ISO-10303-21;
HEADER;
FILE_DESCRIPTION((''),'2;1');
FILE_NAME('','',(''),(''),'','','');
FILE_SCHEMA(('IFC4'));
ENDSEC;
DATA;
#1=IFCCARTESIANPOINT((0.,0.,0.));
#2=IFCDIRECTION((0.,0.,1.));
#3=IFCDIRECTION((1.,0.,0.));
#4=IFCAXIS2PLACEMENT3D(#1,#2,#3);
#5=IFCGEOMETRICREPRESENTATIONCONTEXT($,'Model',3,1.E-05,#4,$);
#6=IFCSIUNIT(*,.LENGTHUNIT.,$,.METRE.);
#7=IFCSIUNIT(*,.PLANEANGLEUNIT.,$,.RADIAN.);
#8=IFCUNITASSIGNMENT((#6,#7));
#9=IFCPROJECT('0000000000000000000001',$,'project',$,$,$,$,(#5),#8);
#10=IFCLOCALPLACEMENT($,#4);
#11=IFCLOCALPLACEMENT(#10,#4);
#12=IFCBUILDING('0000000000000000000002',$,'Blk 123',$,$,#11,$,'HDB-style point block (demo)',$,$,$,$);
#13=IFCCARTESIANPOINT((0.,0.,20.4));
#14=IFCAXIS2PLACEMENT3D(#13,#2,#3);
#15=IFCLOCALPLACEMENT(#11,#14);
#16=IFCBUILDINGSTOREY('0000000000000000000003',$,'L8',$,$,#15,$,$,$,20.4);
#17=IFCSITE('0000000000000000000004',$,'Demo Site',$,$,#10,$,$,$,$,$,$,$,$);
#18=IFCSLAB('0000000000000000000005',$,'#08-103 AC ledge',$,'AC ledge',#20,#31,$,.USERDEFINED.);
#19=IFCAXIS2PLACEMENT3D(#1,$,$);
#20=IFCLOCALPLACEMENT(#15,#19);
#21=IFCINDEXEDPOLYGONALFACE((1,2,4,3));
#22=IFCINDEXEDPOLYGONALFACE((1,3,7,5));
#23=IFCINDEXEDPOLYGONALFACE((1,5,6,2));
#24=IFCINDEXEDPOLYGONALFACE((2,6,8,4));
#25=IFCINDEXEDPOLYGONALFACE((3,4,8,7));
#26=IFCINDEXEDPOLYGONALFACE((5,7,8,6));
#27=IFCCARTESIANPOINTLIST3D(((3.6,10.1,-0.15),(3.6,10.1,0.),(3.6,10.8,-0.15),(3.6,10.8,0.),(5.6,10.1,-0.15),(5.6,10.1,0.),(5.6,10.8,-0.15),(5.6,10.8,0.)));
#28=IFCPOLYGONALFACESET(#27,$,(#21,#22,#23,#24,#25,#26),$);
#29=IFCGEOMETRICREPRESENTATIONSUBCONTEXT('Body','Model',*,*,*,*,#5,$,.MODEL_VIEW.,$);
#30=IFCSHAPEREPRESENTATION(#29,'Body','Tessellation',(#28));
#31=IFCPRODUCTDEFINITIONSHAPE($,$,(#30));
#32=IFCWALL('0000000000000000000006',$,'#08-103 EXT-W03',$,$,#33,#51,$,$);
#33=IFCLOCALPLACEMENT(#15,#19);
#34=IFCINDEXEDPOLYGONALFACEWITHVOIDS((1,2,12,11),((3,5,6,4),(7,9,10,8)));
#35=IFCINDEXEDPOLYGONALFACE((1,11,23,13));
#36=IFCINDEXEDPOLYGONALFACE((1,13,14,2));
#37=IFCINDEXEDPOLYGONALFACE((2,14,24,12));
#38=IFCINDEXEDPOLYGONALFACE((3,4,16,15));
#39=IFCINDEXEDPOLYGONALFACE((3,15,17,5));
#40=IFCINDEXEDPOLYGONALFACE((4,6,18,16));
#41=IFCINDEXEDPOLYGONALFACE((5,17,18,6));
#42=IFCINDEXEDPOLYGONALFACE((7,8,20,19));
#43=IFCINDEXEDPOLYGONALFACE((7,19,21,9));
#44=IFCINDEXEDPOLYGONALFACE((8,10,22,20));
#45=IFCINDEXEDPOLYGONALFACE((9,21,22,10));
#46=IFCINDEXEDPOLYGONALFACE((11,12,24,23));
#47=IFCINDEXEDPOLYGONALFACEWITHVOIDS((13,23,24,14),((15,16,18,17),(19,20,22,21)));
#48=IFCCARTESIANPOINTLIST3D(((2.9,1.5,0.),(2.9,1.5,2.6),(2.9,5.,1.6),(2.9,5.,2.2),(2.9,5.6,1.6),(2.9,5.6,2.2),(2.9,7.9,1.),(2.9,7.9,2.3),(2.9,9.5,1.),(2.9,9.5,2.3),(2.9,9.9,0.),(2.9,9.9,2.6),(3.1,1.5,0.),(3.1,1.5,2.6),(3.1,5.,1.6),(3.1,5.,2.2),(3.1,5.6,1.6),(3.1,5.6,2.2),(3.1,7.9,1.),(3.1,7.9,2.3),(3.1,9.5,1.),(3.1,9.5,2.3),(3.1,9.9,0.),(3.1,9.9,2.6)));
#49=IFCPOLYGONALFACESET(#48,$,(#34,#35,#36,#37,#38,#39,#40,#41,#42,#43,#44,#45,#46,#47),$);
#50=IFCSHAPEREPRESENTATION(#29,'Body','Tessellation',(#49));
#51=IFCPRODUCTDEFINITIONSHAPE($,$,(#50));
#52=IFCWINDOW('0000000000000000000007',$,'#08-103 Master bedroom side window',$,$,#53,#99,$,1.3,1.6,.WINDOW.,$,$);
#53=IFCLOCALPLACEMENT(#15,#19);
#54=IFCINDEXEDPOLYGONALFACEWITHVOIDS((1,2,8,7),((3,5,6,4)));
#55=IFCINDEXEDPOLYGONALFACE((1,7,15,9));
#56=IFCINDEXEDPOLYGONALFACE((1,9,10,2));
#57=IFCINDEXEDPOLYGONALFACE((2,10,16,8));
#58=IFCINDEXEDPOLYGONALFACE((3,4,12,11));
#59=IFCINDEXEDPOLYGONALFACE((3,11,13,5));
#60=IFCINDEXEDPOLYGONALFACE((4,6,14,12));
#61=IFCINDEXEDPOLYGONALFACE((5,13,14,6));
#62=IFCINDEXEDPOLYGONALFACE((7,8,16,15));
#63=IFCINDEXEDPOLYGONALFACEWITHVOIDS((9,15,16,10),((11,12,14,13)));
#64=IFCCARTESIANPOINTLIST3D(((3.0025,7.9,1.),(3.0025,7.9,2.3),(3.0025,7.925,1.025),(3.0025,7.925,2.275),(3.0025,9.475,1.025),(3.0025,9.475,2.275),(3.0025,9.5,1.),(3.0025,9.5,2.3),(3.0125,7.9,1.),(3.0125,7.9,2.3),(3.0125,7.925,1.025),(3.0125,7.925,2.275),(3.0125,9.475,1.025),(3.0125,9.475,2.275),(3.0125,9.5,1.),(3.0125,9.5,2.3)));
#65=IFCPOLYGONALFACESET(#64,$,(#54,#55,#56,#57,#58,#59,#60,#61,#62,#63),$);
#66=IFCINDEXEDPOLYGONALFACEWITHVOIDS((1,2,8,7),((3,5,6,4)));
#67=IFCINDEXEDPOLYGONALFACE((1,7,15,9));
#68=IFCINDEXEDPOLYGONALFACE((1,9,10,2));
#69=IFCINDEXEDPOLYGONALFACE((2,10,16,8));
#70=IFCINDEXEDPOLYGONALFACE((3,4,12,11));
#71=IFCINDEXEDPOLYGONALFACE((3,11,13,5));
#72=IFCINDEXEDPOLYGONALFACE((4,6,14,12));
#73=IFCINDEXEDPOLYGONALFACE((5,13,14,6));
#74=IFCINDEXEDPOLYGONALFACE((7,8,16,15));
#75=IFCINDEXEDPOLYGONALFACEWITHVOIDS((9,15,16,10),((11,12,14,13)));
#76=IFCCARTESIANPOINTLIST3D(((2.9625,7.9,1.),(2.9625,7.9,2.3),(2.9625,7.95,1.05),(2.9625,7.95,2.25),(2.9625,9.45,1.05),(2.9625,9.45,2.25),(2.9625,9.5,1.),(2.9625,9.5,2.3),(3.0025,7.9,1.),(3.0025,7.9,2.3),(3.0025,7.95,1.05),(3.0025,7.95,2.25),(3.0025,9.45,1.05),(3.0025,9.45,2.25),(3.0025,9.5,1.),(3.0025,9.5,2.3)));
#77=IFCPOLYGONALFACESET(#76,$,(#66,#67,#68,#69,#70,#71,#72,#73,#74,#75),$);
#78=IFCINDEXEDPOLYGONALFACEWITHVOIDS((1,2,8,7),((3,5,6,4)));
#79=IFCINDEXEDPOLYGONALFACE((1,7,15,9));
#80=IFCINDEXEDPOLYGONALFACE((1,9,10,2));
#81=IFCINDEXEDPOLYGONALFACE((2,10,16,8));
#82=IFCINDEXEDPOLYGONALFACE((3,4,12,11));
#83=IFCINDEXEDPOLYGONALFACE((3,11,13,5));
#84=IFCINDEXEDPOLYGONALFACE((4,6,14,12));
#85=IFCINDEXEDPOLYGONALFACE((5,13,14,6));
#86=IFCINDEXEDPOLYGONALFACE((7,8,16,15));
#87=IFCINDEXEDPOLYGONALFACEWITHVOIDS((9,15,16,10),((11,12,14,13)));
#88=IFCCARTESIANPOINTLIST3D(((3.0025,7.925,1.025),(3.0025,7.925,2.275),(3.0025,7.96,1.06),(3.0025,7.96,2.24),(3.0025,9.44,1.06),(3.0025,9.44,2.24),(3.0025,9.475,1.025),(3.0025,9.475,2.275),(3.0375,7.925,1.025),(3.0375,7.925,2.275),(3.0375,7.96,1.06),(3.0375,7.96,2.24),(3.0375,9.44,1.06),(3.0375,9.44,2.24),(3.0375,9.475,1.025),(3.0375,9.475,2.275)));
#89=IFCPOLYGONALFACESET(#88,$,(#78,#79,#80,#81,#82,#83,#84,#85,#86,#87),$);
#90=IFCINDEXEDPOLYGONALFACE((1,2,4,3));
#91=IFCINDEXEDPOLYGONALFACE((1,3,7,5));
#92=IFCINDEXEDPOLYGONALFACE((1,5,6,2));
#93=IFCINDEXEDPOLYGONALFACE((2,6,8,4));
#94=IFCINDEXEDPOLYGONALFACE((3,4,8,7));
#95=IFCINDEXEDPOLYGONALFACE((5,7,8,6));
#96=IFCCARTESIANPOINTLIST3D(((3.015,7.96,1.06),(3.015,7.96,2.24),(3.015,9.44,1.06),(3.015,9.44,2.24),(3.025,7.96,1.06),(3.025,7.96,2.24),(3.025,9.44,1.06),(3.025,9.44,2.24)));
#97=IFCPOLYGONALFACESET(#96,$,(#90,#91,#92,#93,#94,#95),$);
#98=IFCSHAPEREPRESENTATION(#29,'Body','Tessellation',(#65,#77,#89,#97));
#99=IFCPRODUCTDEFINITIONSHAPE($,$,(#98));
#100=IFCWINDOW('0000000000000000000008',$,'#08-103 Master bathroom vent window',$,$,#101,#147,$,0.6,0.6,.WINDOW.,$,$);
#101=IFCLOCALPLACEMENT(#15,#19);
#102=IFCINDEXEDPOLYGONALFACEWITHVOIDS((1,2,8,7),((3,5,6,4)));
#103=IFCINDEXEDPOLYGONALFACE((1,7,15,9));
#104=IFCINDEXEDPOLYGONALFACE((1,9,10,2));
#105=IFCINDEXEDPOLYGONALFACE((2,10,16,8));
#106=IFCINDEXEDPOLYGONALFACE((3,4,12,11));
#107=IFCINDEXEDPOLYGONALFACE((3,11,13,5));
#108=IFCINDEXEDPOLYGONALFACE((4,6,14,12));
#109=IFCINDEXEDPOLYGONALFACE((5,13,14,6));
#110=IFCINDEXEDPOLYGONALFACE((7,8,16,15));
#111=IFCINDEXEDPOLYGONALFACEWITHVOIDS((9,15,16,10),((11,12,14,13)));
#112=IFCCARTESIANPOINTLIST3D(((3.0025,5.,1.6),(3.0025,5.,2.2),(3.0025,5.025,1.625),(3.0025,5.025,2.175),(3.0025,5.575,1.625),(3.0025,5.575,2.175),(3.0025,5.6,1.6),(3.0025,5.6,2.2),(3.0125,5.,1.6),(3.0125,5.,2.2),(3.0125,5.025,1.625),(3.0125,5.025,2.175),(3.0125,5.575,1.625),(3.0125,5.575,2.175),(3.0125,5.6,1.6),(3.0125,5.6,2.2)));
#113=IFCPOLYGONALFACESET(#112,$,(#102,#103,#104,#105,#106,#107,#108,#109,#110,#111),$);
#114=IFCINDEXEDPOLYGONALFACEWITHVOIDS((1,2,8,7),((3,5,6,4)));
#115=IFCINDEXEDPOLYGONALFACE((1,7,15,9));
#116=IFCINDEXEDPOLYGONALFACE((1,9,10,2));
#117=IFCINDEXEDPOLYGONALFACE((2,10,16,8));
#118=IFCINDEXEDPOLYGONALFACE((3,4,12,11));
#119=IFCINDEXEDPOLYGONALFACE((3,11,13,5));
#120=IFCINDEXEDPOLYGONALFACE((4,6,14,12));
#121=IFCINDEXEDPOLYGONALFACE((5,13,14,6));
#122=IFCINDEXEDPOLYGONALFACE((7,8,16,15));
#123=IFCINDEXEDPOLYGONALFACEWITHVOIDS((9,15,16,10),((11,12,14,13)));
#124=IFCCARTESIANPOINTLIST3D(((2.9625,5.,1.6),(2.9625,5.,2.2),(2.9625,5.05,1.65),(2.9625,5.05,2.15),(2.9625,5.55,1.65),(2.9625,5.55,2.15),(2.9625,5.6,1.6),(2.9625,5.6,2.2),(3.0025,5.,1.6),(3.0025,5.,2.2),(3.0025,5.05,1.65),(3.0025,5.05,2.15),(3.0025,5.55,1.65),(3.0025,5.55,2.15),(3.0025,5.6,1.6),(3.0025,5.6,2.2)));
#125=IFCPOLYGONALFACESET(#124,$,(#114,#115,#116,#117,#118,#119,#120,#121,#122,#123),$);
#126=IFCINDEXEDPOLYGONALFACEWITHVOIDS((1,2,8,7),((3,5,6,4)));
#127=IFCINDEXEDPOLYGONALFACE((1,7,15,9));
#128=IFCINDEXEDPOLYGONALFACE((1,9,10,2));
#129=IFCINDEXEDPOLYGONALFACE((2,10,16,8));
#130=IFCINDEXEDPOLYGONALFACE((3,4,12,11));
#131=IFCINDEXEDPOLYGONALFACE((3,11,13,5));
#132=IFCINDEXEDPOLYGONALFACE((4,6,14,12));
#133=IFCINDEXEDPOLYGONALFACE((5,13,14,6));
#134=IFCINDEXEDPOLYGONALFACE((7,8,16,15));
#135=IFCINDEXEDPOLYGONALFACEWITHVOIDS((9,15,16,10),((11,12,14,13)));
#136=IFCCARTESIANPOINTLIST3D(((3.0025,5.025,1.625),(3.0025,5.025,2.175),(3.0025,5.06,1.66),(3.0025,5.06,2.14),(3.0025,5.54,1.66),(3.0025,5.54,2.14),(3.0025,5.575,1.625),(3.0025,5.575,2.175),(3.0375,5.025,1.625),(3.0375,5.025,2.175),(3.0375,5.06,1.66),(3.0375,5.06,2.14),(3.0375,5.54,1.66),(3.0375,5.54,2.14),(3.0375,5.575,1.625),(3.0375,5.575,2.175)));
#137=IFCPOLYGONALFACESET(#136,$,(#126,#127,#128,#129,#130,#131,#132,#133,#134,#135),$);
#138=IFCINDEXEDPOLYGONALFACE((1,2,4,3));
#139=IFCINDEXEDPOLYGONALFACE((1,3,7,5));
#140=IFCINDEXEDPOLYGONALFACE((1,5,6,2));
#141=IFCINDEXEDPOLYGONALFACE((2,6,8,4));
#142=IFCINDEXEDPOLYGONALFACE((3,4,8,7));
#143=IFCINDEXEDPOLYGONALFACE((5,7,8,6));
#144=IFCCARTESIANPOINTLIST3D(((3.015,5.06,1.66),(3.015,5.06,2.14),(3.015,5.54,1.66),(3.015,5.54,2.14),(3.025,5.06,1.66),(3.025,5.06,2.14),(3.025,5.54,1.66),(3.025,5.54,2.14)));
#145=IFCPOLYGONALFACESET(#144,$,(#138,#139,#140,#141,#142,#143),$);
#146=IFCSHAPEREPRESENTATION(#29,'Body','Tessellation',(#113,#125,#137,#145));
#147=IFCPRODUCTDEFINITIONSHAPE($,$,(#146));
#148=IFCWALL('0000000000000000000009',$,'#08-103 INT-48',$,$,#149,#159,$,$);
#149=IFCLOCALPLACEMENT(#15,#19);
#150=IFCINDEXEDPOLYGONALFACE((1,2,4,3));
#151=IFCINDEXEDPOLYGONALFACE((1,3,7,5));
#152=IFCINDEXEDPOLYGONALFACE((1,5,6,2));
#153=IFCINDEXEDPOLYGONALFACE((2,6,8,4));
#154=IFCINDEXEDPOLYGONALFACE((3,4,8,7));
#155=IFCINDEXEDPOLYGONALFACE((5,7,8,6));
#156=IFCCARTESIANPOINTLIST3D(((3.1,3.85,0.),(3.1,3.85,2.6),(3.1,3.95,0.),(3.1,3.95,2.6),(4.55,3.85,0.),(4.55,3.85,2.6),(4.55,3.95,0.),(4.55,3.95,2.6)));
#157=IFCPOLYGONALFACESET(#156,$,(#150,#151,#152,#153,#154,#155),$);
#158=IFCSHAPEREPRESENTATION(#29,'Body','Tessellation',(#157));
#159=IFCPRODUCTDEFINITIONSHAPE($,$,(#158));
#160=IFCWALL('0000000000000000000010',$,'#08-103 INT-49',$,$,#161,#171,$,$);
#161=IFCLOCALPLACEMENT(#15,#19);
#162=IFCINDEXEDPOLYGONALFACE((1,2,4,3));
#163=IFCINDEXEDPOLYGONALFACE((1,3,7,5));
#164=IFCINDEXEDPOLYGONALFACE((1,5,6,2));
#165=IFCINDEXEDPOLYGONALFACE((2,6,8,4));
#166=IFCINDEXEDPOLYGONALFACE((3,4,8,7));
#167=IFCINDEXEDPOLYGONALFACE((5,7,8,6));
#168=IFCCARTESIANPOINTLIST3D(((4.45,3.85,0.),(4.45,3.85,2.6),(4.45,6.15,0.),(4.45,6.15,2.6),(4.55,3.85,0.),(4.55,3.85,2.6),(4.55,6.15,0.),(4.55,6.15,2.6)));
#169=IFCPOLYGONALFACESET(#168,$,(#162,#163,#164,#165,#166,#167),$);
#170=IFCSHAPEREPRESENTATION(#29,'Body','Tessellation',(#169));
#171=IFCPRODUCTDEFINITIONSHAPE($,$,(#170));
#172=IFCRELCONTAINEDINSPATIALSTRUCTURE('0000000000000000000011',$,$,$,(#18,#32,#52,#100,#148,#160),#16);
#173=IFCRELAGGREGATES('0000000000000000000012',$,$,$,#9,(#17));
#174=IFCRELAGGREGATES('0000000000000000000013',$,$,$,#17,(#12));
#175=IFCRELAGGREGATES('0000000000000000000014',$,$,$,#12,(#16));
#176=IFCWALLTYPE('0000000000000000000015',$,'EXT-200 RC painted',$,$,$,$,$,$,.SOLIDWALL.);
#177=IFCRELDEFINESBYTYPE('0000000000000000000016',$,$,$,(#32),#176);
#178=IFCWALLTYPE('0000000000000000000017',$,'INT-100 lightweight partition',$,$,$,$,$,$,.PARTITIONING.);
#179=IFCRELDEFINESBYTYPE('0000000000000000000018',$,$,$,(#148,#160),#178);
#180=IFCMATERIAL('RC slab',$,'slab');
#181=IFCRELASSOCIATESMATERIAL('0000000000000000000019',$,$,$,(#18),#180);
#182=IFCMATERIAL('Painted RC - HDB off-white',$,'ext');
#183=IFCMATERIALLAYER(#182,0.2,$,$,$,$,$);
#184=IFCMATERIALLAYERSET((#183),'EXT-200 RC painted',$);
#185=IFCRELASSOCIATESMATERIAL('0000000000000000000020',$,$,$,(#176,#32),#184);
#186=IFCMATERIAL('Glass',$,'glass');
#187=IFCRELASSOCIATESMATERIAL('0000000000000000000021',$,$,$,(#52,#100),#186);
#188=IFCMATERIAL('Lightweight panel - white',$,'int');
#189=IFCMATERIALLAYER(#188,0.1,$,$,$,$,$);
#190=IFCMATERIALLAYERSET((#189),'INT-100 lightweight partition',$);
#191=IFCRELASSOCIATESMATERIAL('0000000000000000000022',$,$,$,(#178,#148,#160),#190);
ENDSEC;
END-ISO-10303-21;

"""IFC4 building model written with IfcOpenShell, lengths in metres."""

from ifc_helpers import new_model, si_unit, frame, origin, origin_with_axes, place, context, subcontext, project, spatial, polyline, line, indexed_curve, outline, extrude, material, layer, layer_set, layer_usage, type_object, element, fill, save


model = new_model("IFC4")

# Units and contexts
model_context = context("Model", 3, precision=1e-05, world=origin_with_axes())
body_context = subcontext(model_context, "Body", "Model", "MODEL_VIEW")
ifc_project = project(units=[si_unit("LENGTHUNIT", "METRE"), si_unit("PLANEANGLEUNIT", "RADIAN")], contexts=[model_context])

# Site, building, storey
site_placement = place(None, origin_with_axes())
site = spatial("IfcSite", under=ifc_project, at=site_placement, Name="Demo Site")
building_placement = place(site_placement, origin_with_axes())
building = spatial("IfcBuilding", under=site, at=building_placement, Name="Blk 123", LongName="HDB-style point block (demo)")
storey_placement = place(building_placement, frame((0.0, 0.0, 20.4), z_axis=(0.0, 0.0, 1.0), x_axis=(1.0, 0.0, 0.0)))
storey = spatial("IfcBuildingStorey", under=building, at=storey_placement, Name="L8", Elevation=20.4)

# Slab
ifc_material_1 = material(Name="RC slab", Category="slab")
slab_placement = place(storey_placement, frame((4.6, 10.45, -0.15), z_axis=(0.0, 0.0, 1.0), x_axis=(1.0, 0.0, 0.0)))
element("IfcSlab", 1, at=slab_placement, inside=storey, material=ifc_material_1, Name="#08-103 AC ledge", ObjectType="AC ledge", PredefinedType="USERDEFINED", context=body_context, shape_type="SweptSolid", body=[
    extrude(outline(polyline([(1.0, -0.35), (1.0, 0.35), (-1.0, 0.35), (-1.0, -0.35), (1.0, -0.35)])), origin(), (0.0, 0.0, 1.0), 0.15),
])

# Wall, openings, windows
ifc_material_2 = material(Name="Painted RC - HDB off-white", Category="ext")
ifc_layer_1 = layer(ifc_material_2, 0.2)
ifc_layer_set_1 = layer_set([ifc_layer_1], Name="EXT-200 RC painted")
ifc_layer_usage_1 = layer_usage(ifc_layer_set_1, "AXIS2", "POSITIVE", 0.0)
wall_type_1 = type_object("IfcWallType", Name="EXT-200 RC painted", PredefinedType="SOLIDWALL", material=ifc_layer_set_1)
wall_1_placement = place(storey_placement, frame((2.9, 9.9, 0.0), z_axis=(0.0, 0.0, 1.0), x_axis=(0.0, -1.0, 0.0)))
wall_1 = element("IfcWall", 2, at=wall_1_placement, inside=storey, type_object=wall_type_1, material=ifc_layer_usage_1, Name="#08-103 EXT-W03", context=body_context, shape_type="SweptSolid", body=[
    extrude(outline(indexed_curve([(0.0, 0.0), (0.0, 0.2), (8.4, 0.2), (8.4, 0.0), (0.0, 0.0)], self_intersect=False)), origin_with_axes(), (0.0, 0.0, 1.0), 2.6),
])
opening_1_placement = place(wall_1_placement, frame((0.4, -0.1, 1.0), z_axis=(0.0, 0.0, 1.0), x_axis=(1.0, 0.0, 0.0)))
opening_1 = element("IfcOpeningElement", 3, at=opening_1_placement, cuts=wall_1, context=body_context, shape_type="SweptSolid", body=[
    extrude(outline(indexed_curve([(0.0, 0.0), (0.0, 0.4), (1.6, 0.4), (1.6, 0.0), (0.0, 0.0)], self_intersect=False)), origin_with_axes(), (0.0, 0.0, 1.0), 1.3),
])
opening_2_placement = place(wall_1_placement, frame((4.3, -0.1, 1.6), z_axis=(0.0, 0.0, 1.0), x_axis=(1.0, 0.0, 0.0)))
opening_2 = element("IfcOpeningElement", 4, at=opening_2_placement, cuts=wall_1, context=body_context, shape_type="SweptSolid", body=[
    extrude(outline(indexed_curve([(0.0, 0.0), (0.0, 0.4), (0.6, 0.4), (0.6, 0.0), (0.0, 0.0)], self_intersect=False)), origin_with_axes(), (0.0, 0.0, 1.0), 0.6),
])
ifc_material_3 = material(Name="Glass", Category="glass")
window_1_placement = place(opening_1_placement, frame((0.0, 0.1125, 0.0), z_axis=(0.0, 0.0, 1.0), x_axis=(1.0, 0.0, 0.0)))
window_1 = element("IfcWindow", 5, at=window_1_placement, inside=storey, material=ifc_material_3, Name="#08-103 Master bedroom side window", OverallHeight=1.3, OverallWidth=1.6, PredefinedType="WINDOW", context=body_context, shape_type="SweptSolid", body=[
    extrude(outline(indexed_curve([(0.0, 0.0), (1.6, 0.0), (1.6, 1.3), (0.0, 1.3)], segments=[line(1, 2, 3, 4, 1)]), holes=[indexed_curve([(0.025, 0.025), (1.575, 0.025), (1.575, 1.275), (0.025, 1.275)], segments=[line(1, 2, 3, 4, 1)])]), frame((0.0, 0.09, 0.0), z_axis=(0.0, -1.0, 0.0), x_axis=(1.0, 0.0, 0.0)), (0.0, 0.0, -1.0), 0.01),
    extrude(outline(indexed_curve([(0.0, 0.0), (1.6, 0.0), (1.6, 1.3), (0.0, 1.3)], segments=[line(1, 2, 3, 4, 1)]), holes=[indexed_curve([(0.05, 0.05), (1.55, 0.05), (1.55, 1.25), (0.05, 1.25)], segments=[line(1, 2, 3, 4, 1)])]), frame((0.0, 0.05, 0.0), z_axis=(0.0, -1.0, 0.0), x_axis=(1.0, 0.0, 0.0)), (0.0, 0.0, -1.0), 0.04),
    extrude(outline(indexed_curve([(0.0, 0.0), (1.55, 0.0), (1.55, 1.25), (0.0, 1.25)], segments=[line(1, 2, 3, 4, 1)]), holes=[indexed_curve([(0.035, 0.035), (1.515, 0.035), (1.515, 1.215), (0.035, 1.215)], segments=[line(1, 2, 3, 4, 1)])]), frame((0.025, 0.09, 0.025), z_axis=(0.0, -1.0, 0.0), x_axis=(1.0, 0.0, 0.0)), (0.0, 0.0, -1.0), 0.035),
    extrude(outline(indexed_curve([(0.035, 0.035), (1.515, 0.035), (1.515, 1.215), (0.035, 1.215)], segments=[line(1, 2, 3, 4, 1)])), frame((0.025, 0.1025, 0.025), z_axis=(0.0, -1.0, 0.0), x_axis=(1.0, 0.0, 0.0)), (0.0, 0.0, -1.0), 0.01),
])
fill(opening_1, window_1)
window_2_placement = place(opening_2_placement, frame((0.0, 0.1125, 0.0), z_axis=(0.0, 0.0, 1.0), x_axis=(1.0, 0.0, 0.0)))
window_2 = element("IfcWindow", 6, at=window_2_placement, inside=storey, material=ifc_material_3, Name="#08-103 Master bathroom vent window", OverallHeight=0.6, OverallWidth=0.6, PredefinedType="WINDOW", context=body_context, shape_type="SweptSolid", body=[
    extrude(outline(indexed_curve([(0.0, 0.0), (0.6, 0.0), (0.6, 0.6), (0.0, 0.6)], segments=[line(1, 2, 3, 4, 1)]), holes=[indexed_curve([(0.025, 0.025), (0.575, 0.025), (0.575, 0.575), (0.025, 0.575)], segments=[line(1, 2, 3, 4, 1)])]), frame((0.0, 0.09, 0.0), z_axis=(0.0, -1.0, 0.0), x_axis=(1.0, 0.0, 0.0)), (0.0, 0.0, -1.0), 0.01),
    extrude(outline(indexed_curve([(0.0, 0.0), (0.6, 0.0), (0.6, 0.6), (0.0, 0.6)], segments=[line(1, 2, 3, 4, 1)]), holes=[indexed_curve([(0.05, 0.05), (0.55, 0.05), (0.55, 0.55), (0.05, 0.55)], segments=[line(1, 2, 3, 4, 1)])]), frame((0.0, 0.05, 0.0), z_axis=(0.0, -1.0, 0.0), x_axis=(1.0, 0.0, 0.0)), (0.0, 0.0, -1.0), 0.04),
    extrude(outline(indexed_curve([(0.0, 0.0), (0.55, 0.0), (0.55, 0.55), (0.0, 0.55)], segments=[line(1, 2, 3, 4, 1)]), holes=[indexed_curve([(0.035, 0.035), (0.515, 0.035), (0.515, 0.515), (0.035, 0.515)], segments=[line(1, 2, 3, 4, 1)])]), frame((0.025, 0.09, 0.025), z_axis=(0.0, -1.0, 0.0), x_axis=(1.0, 0.0, 0.0)), (0.0, 0.0, -1.0), 0.035),
    extrude(outline(indexed_curve([(0.035, 0.035), (0.515, 0.035), (0.515, 0.515), (0.035, 0.515)], segments=[line(1, 2, 3, 4, 1)])), frame((0.025, 0.1025, 0.025), z_axis=(0.0, -1.0, 0.0), x_axis=(1.0, 0.0, 0.0)), (0.0, 0.0, -1.0), 0.01),
])
fill(opening_2, window_2)

# Shared definitions
ifc_material_4 = material(Name="Lightweight panel - white", Category="int")
ifc_layer_2 = layer(ifc_material_4, 0.1)
ifc_layer_set_2 = layer_set([ifc_layer_2], Name="INT-100 lightweight partition")
ifc_layer_usage_2 = layer_usage(ifc_layer_set_2, "AXIS2", "POSITIVE", -0.05)
wall_type_2 = type_object("IfcWallType", Name="INT-100 lightweight partition", PredefinedType="PARTITIONING", material=ifc_layer_set_2)

# Walls
wall_2_placement = place(storey_placement, frame((3.1, 3.9, 0.0), z_axis=(0.0, 0.0, 1.0), x_axis=(1.0, 0.0, 0.0)))
element("IfcWall", 7, at=wall_2_placement, inside=storey, type_object=wall_type_2, material=ifc_layer_usage_2, Name="#08-103 INT-48", context=body_context, shape_type="SweptSolid", body=[
    extrude(outline(indexed_curve([(0.0, 0.0), (0.0, 0.1), (1.45, 0.1), (1.45, 0.0), (0.0, 0.0)], self_intersect=False)), frame((0.0, -0.05, 0.0), z_axis=(0.0, 0.0, 1.0), x_axis=(1.0, 0.0, 0.0)), (0.0, 0.0, 1.0), 2.6),
])
wall_3_placement = place(storey_placement, frame((4.5, 3.85, 0.0), z_axis=(0.0, 0.0, 1.0), x_axis=(0.0, 1.0, 0.0)))
element("IfcWall", 8, at=wall_3_placement, inside=storey, type_object=wall_type_2, material=ifc_layer_usage_2, Name="#08-103 INT-49", context=body_context, shape_type="SweptSolid", body=[
    extrude(outline(indexed_curve([(0.0, 0.0), (0.0, 0.1), (2.3, 0.1), (2.3, 0.0), (0.0, 0.0)], self_intersect=False)), frame((0.0, -0.05, 0.0), z_axis=(0.0, 0.0, 1.0), x_axis=(1.0, 0.0, 0.0)), (0.0, 0.0, 1.0), 2.6),
])

save(model, "model.ifc")
